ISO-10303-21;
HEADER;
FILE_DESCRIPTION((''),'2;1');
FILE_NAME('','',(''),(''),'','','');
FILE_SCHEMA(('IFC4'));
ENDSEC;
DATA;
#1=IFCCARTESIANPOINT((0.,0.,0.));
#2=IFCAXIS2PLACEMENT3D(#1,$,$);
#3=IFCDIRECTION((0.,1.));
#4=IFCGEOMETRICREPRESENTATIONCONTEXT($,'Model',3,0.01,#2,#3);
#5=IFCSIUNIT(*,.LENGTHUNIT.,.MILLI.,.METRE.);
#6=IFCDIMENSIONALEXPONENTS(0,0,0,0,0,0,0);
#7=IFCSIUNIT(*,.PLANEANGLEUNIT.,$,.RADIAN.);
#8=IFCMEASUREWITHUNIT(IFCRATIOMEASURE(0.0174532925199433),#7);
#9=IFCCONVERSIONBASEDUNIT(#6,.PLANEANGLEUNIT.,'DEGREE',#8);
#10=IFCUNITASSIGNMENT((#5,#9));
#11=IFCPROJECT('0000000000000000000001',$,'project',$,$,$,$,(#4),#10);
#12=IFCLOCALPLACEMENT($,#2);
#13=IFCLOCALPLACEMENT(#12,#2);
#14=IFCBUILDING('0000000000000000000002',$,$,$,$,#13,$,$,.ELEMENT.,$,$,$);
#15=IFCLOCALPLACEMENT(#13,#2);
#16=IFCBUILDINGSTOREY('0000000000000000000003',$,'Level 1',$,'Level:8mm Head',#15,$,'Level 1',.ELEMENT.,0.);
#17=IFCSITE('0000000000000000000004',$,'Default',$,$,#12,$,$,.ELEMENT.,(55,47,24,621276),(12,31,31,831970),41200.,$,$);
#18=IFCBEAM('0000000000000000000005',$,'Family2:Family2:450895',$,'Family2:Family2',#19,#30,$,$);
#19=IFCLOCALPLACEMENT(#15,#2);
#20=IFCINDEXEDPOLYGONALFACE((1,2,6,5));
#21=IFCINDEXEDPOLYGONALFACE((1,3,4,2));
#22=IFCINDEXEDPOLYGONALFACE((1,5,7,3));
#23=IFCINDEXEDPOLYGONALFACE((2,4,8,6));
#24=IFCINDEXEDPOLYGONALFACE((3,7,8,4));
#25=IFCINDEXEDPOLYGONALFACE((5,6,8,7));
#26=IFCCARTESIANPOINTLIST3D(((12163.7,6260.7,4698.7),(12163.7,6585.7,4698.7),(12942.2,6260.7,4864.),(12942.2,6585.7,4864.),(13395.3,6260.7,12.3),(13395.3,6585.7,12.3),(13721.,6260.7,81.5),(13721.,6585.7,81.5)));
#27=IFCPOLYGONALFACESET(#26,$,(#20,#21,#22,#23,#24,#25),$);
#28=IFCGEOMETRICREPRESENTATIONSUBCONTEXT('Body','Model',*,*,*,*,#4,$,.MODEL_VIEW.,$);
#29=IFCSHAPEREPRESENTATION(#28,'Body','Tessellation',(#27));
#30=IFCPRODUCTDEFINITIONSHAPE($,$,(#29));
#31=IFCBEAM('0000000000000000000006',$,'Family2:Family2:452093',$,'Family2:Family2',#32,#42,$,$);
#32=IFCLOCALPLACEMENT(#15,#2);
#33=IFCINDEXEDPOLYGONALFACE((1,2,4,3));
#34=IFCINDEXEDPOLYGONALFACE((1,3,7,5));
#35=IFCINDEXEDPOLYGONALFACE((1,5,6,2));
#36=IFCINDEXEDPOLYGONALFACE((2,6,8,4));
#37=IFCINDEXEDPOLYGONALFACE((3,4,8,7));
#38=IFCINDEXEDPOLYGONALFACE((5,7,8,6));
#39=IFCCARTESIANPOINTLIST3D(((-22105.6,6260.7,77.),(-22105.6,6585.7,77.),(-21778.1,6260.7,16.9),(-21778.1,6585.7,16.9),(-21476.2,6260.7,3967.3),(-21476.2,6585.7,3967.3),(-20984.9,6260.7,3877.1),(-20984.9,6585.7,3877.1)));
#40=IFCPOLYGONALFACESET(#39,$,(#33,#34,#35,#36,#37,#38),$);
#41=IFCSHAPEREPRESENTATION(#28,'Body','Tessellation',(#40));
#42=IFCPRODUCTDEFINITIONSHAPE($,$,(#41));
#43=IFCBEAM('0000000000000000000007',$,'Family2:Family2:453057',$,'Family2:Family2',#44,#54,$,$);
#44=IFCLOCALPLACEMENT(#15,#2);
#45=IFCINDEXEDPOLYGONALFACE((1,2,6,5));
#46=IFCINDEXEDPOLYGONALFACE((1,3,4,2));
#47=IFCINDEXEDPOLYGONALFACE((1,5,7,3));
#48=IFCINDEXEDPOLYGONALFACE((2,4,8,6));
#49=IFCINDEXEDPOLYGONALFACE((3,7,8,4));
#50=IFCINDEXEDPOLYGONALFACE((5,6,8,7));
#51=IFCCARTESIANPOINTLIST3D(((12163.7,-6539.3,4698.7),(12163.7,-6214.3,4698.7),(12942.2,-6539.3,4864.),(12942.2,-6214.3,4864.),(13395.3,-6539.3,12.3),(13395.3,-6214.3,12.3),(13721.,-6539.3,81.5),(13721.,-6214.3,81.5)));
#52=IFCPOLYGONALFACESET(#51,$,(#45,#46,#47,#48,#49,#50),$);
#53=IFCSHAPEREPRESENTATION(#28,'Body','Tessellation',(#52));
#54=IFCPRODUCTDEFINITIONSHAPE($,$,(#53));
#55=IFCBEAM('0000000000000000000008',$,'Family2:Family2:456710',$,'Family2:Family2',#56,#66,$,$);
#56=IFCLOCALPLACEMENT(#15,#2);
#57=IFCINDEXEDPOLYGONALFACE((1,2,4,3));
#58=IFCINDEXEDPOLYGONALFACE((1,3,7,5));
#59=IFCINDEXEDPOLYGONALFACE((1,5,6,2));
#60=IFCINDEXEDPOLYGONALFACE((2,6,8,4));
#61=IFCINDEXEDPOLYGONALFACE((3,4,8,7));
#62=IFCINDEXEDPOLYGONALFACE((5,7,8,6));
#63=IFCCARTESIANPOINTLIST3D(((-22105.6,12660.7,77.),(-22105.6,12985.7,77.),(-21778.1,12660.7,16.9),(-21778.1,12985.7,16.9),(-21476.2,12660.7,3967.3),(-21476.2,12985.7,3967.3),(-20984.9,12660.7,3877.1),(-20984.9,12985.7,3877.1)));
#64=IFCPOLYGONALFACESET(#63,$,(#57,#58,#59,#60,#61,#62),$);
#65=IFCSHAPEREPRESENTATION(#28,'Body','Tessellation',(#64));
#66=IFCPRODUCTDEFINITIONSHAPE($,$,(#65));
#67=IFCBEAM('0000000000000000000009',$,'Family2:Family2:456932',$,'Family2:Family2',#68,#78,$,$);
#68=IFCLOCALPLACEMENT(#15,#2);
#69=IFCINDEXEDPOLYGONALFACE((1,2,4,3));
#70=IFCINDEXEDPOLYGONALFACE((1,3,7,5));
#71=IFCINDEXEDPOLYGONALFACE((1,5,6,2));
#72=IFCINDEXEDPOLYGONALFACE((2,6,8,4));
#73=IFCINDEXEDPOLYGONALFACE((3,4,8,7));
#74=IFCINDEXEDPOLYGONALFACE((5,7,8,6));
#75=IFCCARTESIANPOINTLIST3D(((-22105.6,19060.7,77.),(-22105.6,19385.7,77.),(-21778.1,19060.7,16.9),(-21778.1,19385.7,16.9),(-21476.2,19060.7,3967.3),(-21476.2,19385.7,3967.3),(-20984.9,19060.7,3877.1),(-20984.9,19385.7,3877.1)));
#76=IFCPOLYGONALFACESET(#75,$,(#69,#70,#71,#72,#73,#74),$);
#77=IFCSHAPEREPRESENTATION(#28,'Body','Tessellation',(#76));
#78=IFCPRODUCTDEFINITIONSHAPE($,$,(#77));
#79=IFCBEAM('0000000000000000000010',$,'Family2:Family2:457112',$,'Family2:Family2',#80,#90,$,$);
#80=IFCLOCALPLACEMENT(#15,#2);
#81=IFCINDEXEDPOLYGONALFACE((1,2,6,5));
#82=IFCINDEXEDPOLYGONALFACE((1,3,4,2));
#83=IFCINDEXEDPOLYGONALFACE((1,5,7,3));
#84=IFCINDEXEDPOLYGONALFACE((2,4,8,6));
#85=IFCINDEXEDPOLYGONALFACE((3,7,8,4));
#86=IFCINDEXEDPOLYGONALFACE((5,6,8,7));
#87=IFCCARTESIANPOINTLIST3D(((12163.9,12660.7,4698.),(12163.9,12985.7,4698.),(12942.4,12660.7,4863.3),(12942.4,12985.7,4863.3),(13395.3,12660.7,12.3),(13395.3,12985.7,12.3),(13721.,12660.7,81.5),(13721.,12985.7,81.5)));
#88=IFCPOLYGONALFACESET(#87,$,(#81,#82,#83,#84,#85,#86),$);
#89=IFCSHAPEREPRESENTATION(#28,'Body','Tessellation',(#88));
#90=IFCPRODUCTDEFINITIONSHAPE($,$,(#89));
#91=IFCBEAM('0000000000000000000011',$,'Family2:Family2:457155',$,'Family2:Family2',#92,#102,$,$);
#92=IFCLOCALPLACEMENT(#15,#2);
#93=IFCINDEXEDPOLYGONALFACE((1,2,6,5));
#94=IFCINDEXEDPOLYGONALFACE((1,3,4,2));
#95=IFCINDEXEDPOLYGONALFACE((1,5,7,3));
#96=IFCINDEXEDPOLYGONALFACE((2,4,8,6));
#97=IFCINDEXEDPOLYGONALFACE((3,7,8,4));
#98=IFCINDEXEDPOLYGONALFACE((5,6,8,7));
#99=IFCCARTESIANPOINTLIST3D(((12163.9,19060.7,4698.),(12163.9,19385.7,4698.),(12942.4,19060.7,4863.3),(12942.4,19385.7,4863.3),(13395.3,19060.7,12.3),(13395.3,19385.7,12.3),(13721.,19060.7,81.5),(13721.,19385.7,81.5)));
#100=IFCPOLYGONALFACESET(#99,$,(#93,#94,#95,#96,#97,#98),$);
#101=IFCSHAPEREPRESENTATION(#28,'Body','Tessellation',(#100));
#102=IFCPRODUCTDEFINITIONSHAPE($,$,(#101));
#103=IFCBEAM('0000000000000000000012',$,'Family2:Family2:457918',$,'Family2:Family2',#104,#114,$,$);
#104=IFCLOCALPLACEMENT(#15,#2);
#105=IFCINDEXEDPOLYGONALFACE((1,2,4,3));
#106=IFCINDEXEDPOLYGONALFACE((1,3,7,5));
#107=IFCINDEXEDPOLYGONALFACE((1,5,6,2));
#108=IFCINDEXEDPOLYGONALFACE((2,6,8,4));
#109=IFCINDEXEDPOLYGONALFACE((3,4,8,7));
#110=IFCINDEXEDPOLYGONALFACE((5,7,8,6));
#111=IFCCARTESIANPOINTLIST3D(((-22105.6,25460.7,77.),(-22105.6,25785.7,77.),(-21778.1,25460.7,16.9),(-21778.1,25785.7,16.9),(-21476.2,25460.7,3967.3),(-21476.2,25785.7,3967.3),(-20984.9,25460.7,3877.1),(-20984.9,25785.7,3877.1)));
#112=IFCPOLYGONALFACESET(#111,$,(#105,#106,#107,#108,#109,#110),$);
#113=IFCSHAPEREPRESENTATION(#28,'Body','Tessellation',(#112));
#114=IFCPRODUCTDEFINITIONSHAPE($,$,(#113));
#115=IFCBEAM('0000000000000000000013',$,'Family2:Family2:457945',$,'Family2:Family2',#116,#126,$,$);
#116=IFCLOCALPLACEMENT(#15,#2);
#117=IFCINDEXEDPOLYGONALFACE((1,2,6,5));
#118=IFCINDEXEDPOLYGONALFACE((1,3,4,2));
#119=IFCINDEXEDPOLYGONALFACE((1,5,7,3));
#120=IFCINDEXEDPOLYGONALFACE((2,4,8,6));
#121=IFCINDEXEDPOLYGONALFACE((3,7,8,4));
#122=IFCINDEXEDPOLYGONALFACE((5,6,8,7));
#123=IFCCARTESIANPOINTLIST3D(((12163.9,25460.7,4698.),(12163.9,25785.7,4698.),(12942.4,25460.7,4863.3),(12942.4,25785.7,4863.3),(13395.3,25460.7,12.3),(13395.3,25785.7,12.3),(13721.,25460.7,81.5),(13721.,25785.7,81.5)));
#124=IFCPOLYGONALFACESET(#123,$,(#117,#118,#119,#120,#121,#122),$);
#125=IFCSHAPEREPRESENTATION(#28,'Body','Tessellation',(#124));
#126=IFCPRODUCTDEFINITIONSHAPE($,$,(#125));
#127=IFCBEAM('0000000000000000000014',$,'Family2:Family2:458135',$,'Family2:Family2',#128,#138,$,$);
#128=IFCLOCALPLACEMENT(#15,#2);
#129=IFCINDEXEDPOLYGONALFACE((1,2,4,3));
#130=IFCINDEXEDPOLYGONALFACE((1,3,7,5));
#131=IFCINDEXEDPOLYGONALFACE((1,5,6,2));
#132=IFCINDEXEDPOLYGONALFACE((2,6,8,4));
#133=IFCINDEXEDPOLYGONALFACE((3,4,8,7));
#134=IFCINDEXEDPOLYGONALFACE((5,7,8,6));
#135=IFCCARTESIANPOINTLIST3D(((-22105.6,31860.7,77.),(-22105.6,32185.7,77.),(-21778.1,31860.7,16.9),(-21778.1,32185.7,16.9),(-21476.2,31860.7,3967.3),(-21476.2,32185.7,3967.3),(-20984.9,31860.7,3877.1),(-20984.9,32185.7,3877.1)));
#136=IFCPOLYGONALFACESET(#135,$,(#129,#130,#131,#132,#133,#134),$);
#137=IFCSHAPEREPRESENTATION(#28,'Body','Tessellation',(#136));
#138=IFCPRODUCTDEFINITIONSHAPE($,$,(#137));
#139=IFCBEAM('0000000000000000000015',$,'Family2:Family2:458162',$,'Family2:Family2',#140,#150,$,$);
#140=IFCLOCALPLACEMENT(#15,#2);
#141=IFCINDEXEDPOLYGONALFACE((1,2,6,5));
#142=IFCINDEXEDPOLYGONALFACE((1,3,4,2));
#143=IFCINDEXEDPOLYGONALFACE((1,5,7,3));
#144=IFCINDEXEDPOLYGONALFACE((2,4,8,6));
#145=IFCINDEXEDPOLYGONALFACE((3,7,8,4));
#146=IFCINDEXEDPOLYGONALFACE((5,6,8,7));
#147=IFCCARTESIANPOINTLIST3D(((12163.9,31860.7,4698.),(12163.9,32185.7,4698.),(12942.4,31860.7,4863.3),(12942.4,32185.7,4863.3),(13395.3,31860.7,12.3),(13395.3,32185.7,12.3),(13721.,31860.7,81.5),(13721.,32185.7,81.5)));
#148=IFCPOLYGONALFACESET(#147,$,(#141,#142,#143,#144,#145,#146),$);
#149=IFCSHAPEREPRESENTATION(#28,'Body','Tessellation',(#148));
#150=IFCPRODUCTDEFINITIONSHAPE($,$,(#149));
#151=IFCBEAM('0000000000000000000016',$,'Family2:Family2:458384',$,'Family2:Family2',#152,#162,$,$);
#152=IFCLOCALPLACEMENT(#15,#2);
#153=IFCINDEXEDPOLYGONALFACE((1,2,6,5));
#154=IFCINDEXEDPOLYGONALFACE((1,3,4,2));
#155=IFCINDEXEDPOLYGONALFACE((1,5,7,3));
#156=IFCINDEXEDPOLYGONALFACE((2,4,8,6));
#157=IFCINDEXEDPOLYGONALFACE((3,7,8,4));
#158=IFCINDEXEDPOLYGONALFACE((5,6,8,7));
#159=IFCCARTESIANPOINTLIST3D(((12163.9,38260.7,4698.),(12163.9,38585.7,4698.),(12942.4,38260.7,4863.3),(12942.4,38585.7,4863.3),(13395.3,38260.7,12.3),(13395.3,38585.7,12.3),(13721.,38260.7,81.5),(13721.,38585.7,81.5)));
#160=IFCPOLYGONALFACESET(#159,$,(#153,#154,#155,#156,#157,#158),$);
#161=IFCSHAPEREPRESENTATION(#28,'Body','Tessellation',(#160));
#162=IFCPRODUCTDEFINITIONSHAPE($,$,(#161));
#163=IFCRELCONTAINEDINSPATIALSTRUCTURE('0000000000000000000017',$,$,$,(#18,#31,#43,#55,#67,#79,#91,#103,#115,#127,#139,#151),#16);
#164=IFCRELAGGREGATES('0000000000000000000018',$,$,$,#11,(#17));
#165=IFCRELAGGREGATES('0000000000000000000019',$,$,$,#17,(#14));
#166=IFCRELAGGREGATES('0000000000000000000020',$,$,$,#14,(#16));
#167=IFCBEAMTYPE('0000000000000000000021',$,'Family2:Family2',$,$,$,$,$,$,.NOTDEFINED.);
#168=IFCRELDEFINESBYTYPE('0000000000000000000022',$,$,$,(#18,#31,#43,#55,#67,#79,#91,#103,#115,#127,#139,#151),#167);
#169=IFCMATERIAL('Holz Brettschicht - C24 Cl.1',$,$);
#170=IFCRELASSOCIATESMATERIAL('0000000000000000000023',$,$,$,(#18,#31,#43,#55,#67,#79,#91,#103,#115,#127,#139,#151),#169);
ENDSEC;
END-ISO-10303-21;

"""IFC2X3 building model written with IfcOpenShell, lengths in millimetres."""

from ifc_helpers import new_model, entity, si_unit, converted_unit, direction, frame, frame_2d, origin, place, context, subcontext, project, spatial, rectangle, extrude, clip, halfspace, material, type_object, element, save


model = new_model("IFC2X3")

# Units and contexts
model_context = context("Model", 3, precision=0.01, world=origin(), true_north=direction((0.0, 1.0)))
body_context = subcontext(model_context, "Body", "Model", "MODEL_VIEW")
ifc_project = project(units=[si_unit("LENGTHUNIT", "METRE", prefix="MILLI"), converted_unit("PLANEANGLEUNIT", "DEGREE", entity("IfcRatioMeasure", 0.0174532925199433), si_unit("PLANEANGLEUNIT", "RADIAN"), dimensions=[0, 0, 0, 0, 0, 0, 0])], contexts=[model_context])

# Site, building, storey
site_placement = place(None, origin())
site = spatial("IfcSite", under=ifc_project, at=site_placement, Name="Default", CompositionType="ELEMENT", RefLatitude=(55, 47, 24, 621276), RefLongitude=(12, 31, 31, 831970), RefElevation=41200.0)
building_placement = place(site_placement, origin())
building = spatial("IfcBuilding", under=site, at=building_placement, CompositionType="ELEMENT")
storey_placement = place(building_placement, origin())
storey = spatial("IfcBuildingStorey", under=building, at=storey_placement, Name="Level 1", ObjectType="Level:8mm Head", LongName="Level 1", CompositionType="ELEMENT", Elevation=0.0)

# Shared definitions
ifc_material_1 = material(Name="Holz Brettschicht - C24 Cl.1")

# Beams
beam_type_1 = type_object("IfcBeamType", Name="Family2:Family2", PredefinedType="NOTDEFINED")
beam_1_placement = place(storey_placement, frame((12553.0, 6423.2, 4781.4), z_axis=(0.978196, 0.0, 0.207685), x_axis=(0.207685, 0.0, -0.978196)))
element("IfcBeam", 1, at=beam_1_placement, inside=storey, type_object=beam_type_1, material=ifc_material_1, Name="Family2:Family2:450895", ObjectType="Family2:Family2", context=body_context, shape_type="Clipping", body=[
    clip(clip(extrude(rectangle(XDim=795.9, YDim=325.0, at=frame_2d((0.0, 0.0), x_axis=(0.0, 1.0))), frame((0.0, 0.0, 0.0), z_axis=(1.0, 0.0, 0.0), x_axis=(0.0, 1.0, 0.0)), (0.0, 0.0, 1.0), 4840.0), halfspace(frame((0.0, 0.0, -397.9), z_axis=(0.047766, 0.0, -0.998859), x_axis=(0.0, 1.0, 0.0)), False)), halfspace(frame((0.0, 0.0, 397.9), z_axis=(0.047766, 0.0, 0.998859), x_axis=(0.0, -1.0, 0.0)), False)),
])
beam_2_placement = place(storey_placement, frame((-21941.8, 6423.2, 46.9), z_axis=(0.983571, 0.0, -0.180519), x_axis=(0.180519, 0.0, 0.983571)))
element("IfcBeam", 2, at=beam_2_placement, inside=storey, type_object=beam_type_1, material=ifc_material_1, Name="Family2:Family2:452093", ObjectType="Family2:Family2", context=body_context, shape_type="Clipping", body=[
    clip(clip(extrude(rectangle(XDim=499.5, YDim=325.0, at=frame_2d((0.0, 0.0), x_axis=(0.0, 1.0))), frame((0.0, 0.0, 0.0), z_axis=(1.0, 0.0, 0.0), x_axis=(0.0, 1.0, 0.0)), (0.0, 0.0, 1.0), 3940.0), halfspace(frame((0.0, 0.0, 166.5), z_axis=(-0.021125, 0.0, 0.999777), x_axis=(0.0, -1.0, 0.0)), False)), halfspace(frame((0.0, 0.0, -166.5), z_axis=(-0.021125, 0.0, -0.999777), x_axis=(0.0, 1.0, 0.0)), False)),
])
beam_3_placement = place(storey_placement, frame((12553.0, -6376.8, 4781.4), z_axis=(0.978196, 0.0, 0.207685), x_axis=(0.207685, 0.0, -0.978196)))
element("IfcBeam", 3, at=beam_3_placement, inside=storey, type_object=beam_type_1, material=ifc_material_1, Name="Family2:Family2:453057", ObjectType="Family2:Family2", context=body_context, shape_type="Clipping", body=[
    clip(clip(extrude(rectangle(XDim=795.9, YDim=325.0, at=frame_2d((0.0, 0.0), x_axis=(0.0, 1.0))), frame((0.0, 0.0, 0.0), z_axis=(1.0, 0.0, 0.0), x_axis=(0.0, 1.0, 0.0)), (0.0, 0.0, 1.0), 4840.0), halfspace(frame((0.0, 0.0, -398.0), z_axis=(0.047766, 0.0, -0.998859), x_axis=(0.0, 1.0, 0.0)), False)), halfspace(frame((0.0, 0.0, 397.9), z_axis=(0.047766, 0.0, 0.998859), x_axis=(0.0, -1.0, 0.0)), False)),
])
beam_4_placement = place(storey_placement, frame((-21941.8, 12823.2, 46.9), z_axis=(0.983571, 0.0, -0.180519), x_axis=(0.180519, 0.0, 0.983571)))
element("IfcBeam", 4, at=beam_4_placement, inside=storey, type_object=beam_type_1, material=ifc_material_1, Name="Family2:Family2:456710", ObjectType="Family2:Family2", context=body_context, shape_type="Clipping", body=[
    clip(clip(extrude(rectangle(XDim=499.5, YDim=325.0, at=frame_2d((0.0, 0.0), x_axis=(0.0, 1.0))), frame((0.0, 0.0, 0.0), z_axis=(1.0, 0.0, 0.0), x_axis=(0.0, 1.0, 0.0)), (0.0, 0.0, 1.0), 3940.0), halfspace(frame((0.0, 0.0, 166.5), z_axis=(-0.021125, 0.0, 0.999777), x_axis=(0.0, -1.0, 0.0)), False)), halfspace(frame((0.0, 0.0, -166.5), z_axis=(-0.021125, 0.0, -0.999777), x_axis=(0.0, 1.0, 0.0)), False)),
])
beam_5_placement = place(storey_placement, frame((-21941.8, 19223.2, 46.9), z_axis=(0.983571, 0.0, -0.180519), x_axis=(0.180519, 0.0, 0.983571)))
element("IfcBeam", 5, at=beam_5_placement, inside=storey, type_object=beam_type_1, material=ifc_material_1, Name="Family2:Family2:456932", ObjectType="Family2:Family2", context=body_context, shape_type="Clipping", body=[
    clip(clip(extrude(rectangle(XDim=499.5, YDim=325.0, at=frame_2d((0.0, 0.0), x_axis=(0.0, 1.0))), frame((0.0, 0.0, 0.0), z_axis=(1.0, 0.0, 0.0), x_axis=(0.0, 1.0, 0.0)), (0.0, 0.0, 1.0), 3940.0), halfspace(frame((0.0, 0.0, 166.5), z_axis=(-0.021125, 0.0, 0.999777), x_axis=(0.0, -1.0, 0.0)), False)), halfspace(frame((0.0, 0.0, -166.5), z_axis=(-0.021125, 0.0, -0.999777), x_axis=(0.0, 1.0, 0.0)), False)),
])
beam_6_placement = place(storey_placement, frame((12553.1, 12823.2, 4780.6), z_axis=(0.978196, 0.0, 0.207685), x_axis=(0.207685, 0.0, -0.978196)))
element("IfcBeam", 6, at=beam_6_placement, inside=storey, type_object=beam_type_1, material=ifc_material_1, Name="Family2:Family2:457112", ObjectType="Family2:Family2", context=body_context, shape_type="Clipping", body=[
    clip(clip(extrude(rectangle(XDim=795.9, YDim=325.0, at=frame_2d((0.0, 0.0), x_axis=(0.0, 1.0))), frame((0.0, 0.0, 0.0), z_axis=(1.0, 0.0, 0.0), x_axis=(0.0, 1.0, 0.0)), (0.0, 0.0, 1.0), 4839.2), halfspace(frame((0.0, 0.0, -398.0), z_axis=(0.047773, 0.0, -0.998858), x_axis=(0.0, 1.0, 0.0)), False)), halfspace(frame((0.0, 0.0, 397.9), z_axis=(0.047773, 0.0, 0.998858), x_axis=(0.0, -1.0, 0.0)), False)),
])
beam_7_placement = place(storey_placement, frame((12553.1, 19223.2, 4780.6), z_axis=(0.978196, 0.0, 0.207685), x_axis=(0.207685, 0.0, -0.978196)))
element("IfcBeam", 7, at=beam_7_placement, inside=storey, type_object=beam_type_1, material=ifc_material_1, Name="Family2:Family2:457155", ObjectType="Family2:Family2", context=body_context, shape_type="Clipping", body=[
    clip(clip(extrude(rectangle(XDim=795.9, YDim=325.0, at=frame_2d((0.0, 0.0), x_axis=(0.0, 1.0))), frame((0.0, 0.0, 0.0), z_axis=(1.0, 0.0, 0.0), x_axis=(0.0, 1.0, 0.0)), (0.0, 0.0, 1.0), 4839.2), halfspace(frame((0.0, 0.0, -398.0), z_axis=(0.047773, 0.0, -0.998858), x_axis=(0.0, 1.0, 0.0)), False)), halfspace(frame((0.0, 0.0, 397.9), z_axis=(0.047773, 0.0, 0.998858), x_axis=(0.0, -1.0, 0.0)), False)),
])
beam_8_placement = place(storey_placement, frame((-21941.8, 25623.2, 46.9), z_axis=(0.983571, 0.0, -0.180519), x_axis=(0.180519, 0.0, 0.983571)))
element("IfcBeam", 8, at=beam_8_placement, inside=storey, type_object=beam_type_1, material=ifc_material_1, Name="Family2:Family2:457918", ObjectType="Family2:Family2", context=body_context, shape_type="Clipping", body=[
    clip(clip(extrude(rectangle(XDim=499.5, YDim=325.0, at=frame_2d((0.0, 0.0), x_axis=(0.0, 1.0))), frame((0.0, 0.0, 0.0), z_axis=(1.0, 0.0, 0.0), x_axis=(0.0, 1.0, 0.0)), (0.0, 0.0, 1.0), 3940.0), halfspace(frame((0.0, 0.0, 166.5), z_axis=(-0.021125, 0.0, 0.999777), x_axis=(0.0, -1.0, 0.0)), False)), halfspace(frame((0.0, 0.0, -166.5), z_axis=(-0.021125, 0.0, -0.999777), x_axis=(0.0, 1.0, 0.0)), False)),
])
beam_9_placement = place(storey_placement, frame((12553.1, 25623.2, 4780.6), z_axis=(0.978196, 0.0, 0.207685), x_axis=(0.207685, 0.0, -0.978196)))
element("IfcBeam", 9, at=beam_9_placement, inside=storey, type_object=beam_type_1, material=ifc_material_1, Name="Family2:Family2:457945", ObjectType="Family2:Family2", context=body_context, shape_type="Clipping", body=[
    clip(clip(extrude(rectangle(XDim=795.9, YDim=325.0, at=frame_2d((0.0, 0.0), x_axis=(0.0, 1.0))), frame((0.0, 0.0, 0.0), z_axis=(1.0, 0.0, 0.0), x_axis=(0.0, 1.0, 0.0)), (0.0, 0.0, 1.0), 4839.2), halfspace(frame((0.0, 0.0, -397.9), z_axis=(0.047773, 0.0, -0.998858), x_axis=(0.0, 1.0, 0.0)), False)), halfspace(frame((0.0, 0.0, 397.9), z_axis=(0.047773, 0.0, 0.998858), x_axis=(0.0, -1.0, 0.0)), False)),
])
beam_10_placement = place(storey_placement, frame((-21941.8, 32023.2, 46.9), z_axis=(0.983571, 0.0, -0.180519), x_axis=(0.180519, 0.0, 0.983571)))
element("IfcBeam", 10, at=beam_10_placement, inside=storey, type_object=beam_type_1, material=ifc_material_1, Name="Family2:Family2:458135", ObjectType="Family2:Family2", context=body_context, shape_type="Clipping", body=[
    clip(clip(extrude(rectangle(XDim=499.5, YDim=325.0, at=frame_2d((0.0, 0.0), x_axis=(0.0, 1.0))), frame((0.0, 0.0, 0.0), z_axis=(1.0, 0.0, 0.0), x_axis=(0.0, 1.0, 0.0)), (0.0, 0.0, 1.0), 3940.0), halfspace(frame((0.0, 0.0, 166.5), z_axis=(-0.021125, 0.0, 0.999777), x_axis=(0.0, -1.0, 0.0)), False)), halfspace(frame((0.0, 0.0, -166.5), z_axis=(-0.021125, 0.0, -0.999777), x_axis=(0.0, 1.0, 0.0)), False)),
])
beam_11_placement = place(storey_placement, frame((12553.1, 32023.2, 4780.6), z_axis=(0.978196, 0.0, 0.207685), x_axis=(0.207685, 0.0, -0.978196)))
element("IfcBeam", 11, at=beam_11_placement, inside=storey, type_object=beam_type_1, material=ifc_material_1, Name="Family2:Family2:458162", ObjectType="Family2:Family2", context=body_context, shape_type="Clipping", body=[
    clip(clip(extrude(rectangle(XDim=795.9, YDim=325.0, at=frame_2d((0.0, 0.0), x_axis=(0.0, 1.0))), frame((0.0, 0.0, 0.0), z_axis=(1.0, 0.0, 0.0), x_axis=(0.0, 1.0, 0.0)), (0.0, 0.0, 1.0), 4839.2), halfspace(frame((0.0, 0.0, -397.9), z_axis=(0.047773, 0.0, -0.998858), x_axis=(0.0, 1.0, 0.0)), False)), halfspace(frame((0.0, 0.0, 397.9), z_axis=(0.047773, 0.0, 0.998858), x_axis=(0.0, -1.0, 0.0)), False)),
])
beam_12_placement = place(storey_placement, frame((12553.1, 38423.2, 4780.6), z_axis=(0.978196, 0.0, 0.207685), x_axis=(0.207685, 0.0, -0.978196)))
element("IfcBeam", 12, at=beam_12_placement, inside=storey, type_object=beam_type_1, material=ifc_material_1, Name="Family2:Family2:458384", ObjectType="Family2:Family2", context=body_context, shape_type="Clipping", body=[
    clip(clip(extrude(rectangle(XDim=795.9, YDim=325.0, at=frame_2d((0.0, 0.0), x_axis=(0.0, 1.0))), frame((0.0, 0.0, 0.0), z_axis=(1.0, 0.0, 0.0), x_axis=(0.0, 1.0, 0.0)), (0.0, 0.0, 1.0), 4839.2), halfspace(frame((0.0, 0.0, -397.9), z_axis=(0.047773, 0.0, -0.998858), x_axis=(0.0, 1.0, 0.0)), False)), halfspace(frame((0.0, 0.0, 397.9), z_axis=(0.047773, 0.0, 0.998858), x_axis=(0.0, -1.0, 0.0)), False)),
])

save(model, "model.ifc")
